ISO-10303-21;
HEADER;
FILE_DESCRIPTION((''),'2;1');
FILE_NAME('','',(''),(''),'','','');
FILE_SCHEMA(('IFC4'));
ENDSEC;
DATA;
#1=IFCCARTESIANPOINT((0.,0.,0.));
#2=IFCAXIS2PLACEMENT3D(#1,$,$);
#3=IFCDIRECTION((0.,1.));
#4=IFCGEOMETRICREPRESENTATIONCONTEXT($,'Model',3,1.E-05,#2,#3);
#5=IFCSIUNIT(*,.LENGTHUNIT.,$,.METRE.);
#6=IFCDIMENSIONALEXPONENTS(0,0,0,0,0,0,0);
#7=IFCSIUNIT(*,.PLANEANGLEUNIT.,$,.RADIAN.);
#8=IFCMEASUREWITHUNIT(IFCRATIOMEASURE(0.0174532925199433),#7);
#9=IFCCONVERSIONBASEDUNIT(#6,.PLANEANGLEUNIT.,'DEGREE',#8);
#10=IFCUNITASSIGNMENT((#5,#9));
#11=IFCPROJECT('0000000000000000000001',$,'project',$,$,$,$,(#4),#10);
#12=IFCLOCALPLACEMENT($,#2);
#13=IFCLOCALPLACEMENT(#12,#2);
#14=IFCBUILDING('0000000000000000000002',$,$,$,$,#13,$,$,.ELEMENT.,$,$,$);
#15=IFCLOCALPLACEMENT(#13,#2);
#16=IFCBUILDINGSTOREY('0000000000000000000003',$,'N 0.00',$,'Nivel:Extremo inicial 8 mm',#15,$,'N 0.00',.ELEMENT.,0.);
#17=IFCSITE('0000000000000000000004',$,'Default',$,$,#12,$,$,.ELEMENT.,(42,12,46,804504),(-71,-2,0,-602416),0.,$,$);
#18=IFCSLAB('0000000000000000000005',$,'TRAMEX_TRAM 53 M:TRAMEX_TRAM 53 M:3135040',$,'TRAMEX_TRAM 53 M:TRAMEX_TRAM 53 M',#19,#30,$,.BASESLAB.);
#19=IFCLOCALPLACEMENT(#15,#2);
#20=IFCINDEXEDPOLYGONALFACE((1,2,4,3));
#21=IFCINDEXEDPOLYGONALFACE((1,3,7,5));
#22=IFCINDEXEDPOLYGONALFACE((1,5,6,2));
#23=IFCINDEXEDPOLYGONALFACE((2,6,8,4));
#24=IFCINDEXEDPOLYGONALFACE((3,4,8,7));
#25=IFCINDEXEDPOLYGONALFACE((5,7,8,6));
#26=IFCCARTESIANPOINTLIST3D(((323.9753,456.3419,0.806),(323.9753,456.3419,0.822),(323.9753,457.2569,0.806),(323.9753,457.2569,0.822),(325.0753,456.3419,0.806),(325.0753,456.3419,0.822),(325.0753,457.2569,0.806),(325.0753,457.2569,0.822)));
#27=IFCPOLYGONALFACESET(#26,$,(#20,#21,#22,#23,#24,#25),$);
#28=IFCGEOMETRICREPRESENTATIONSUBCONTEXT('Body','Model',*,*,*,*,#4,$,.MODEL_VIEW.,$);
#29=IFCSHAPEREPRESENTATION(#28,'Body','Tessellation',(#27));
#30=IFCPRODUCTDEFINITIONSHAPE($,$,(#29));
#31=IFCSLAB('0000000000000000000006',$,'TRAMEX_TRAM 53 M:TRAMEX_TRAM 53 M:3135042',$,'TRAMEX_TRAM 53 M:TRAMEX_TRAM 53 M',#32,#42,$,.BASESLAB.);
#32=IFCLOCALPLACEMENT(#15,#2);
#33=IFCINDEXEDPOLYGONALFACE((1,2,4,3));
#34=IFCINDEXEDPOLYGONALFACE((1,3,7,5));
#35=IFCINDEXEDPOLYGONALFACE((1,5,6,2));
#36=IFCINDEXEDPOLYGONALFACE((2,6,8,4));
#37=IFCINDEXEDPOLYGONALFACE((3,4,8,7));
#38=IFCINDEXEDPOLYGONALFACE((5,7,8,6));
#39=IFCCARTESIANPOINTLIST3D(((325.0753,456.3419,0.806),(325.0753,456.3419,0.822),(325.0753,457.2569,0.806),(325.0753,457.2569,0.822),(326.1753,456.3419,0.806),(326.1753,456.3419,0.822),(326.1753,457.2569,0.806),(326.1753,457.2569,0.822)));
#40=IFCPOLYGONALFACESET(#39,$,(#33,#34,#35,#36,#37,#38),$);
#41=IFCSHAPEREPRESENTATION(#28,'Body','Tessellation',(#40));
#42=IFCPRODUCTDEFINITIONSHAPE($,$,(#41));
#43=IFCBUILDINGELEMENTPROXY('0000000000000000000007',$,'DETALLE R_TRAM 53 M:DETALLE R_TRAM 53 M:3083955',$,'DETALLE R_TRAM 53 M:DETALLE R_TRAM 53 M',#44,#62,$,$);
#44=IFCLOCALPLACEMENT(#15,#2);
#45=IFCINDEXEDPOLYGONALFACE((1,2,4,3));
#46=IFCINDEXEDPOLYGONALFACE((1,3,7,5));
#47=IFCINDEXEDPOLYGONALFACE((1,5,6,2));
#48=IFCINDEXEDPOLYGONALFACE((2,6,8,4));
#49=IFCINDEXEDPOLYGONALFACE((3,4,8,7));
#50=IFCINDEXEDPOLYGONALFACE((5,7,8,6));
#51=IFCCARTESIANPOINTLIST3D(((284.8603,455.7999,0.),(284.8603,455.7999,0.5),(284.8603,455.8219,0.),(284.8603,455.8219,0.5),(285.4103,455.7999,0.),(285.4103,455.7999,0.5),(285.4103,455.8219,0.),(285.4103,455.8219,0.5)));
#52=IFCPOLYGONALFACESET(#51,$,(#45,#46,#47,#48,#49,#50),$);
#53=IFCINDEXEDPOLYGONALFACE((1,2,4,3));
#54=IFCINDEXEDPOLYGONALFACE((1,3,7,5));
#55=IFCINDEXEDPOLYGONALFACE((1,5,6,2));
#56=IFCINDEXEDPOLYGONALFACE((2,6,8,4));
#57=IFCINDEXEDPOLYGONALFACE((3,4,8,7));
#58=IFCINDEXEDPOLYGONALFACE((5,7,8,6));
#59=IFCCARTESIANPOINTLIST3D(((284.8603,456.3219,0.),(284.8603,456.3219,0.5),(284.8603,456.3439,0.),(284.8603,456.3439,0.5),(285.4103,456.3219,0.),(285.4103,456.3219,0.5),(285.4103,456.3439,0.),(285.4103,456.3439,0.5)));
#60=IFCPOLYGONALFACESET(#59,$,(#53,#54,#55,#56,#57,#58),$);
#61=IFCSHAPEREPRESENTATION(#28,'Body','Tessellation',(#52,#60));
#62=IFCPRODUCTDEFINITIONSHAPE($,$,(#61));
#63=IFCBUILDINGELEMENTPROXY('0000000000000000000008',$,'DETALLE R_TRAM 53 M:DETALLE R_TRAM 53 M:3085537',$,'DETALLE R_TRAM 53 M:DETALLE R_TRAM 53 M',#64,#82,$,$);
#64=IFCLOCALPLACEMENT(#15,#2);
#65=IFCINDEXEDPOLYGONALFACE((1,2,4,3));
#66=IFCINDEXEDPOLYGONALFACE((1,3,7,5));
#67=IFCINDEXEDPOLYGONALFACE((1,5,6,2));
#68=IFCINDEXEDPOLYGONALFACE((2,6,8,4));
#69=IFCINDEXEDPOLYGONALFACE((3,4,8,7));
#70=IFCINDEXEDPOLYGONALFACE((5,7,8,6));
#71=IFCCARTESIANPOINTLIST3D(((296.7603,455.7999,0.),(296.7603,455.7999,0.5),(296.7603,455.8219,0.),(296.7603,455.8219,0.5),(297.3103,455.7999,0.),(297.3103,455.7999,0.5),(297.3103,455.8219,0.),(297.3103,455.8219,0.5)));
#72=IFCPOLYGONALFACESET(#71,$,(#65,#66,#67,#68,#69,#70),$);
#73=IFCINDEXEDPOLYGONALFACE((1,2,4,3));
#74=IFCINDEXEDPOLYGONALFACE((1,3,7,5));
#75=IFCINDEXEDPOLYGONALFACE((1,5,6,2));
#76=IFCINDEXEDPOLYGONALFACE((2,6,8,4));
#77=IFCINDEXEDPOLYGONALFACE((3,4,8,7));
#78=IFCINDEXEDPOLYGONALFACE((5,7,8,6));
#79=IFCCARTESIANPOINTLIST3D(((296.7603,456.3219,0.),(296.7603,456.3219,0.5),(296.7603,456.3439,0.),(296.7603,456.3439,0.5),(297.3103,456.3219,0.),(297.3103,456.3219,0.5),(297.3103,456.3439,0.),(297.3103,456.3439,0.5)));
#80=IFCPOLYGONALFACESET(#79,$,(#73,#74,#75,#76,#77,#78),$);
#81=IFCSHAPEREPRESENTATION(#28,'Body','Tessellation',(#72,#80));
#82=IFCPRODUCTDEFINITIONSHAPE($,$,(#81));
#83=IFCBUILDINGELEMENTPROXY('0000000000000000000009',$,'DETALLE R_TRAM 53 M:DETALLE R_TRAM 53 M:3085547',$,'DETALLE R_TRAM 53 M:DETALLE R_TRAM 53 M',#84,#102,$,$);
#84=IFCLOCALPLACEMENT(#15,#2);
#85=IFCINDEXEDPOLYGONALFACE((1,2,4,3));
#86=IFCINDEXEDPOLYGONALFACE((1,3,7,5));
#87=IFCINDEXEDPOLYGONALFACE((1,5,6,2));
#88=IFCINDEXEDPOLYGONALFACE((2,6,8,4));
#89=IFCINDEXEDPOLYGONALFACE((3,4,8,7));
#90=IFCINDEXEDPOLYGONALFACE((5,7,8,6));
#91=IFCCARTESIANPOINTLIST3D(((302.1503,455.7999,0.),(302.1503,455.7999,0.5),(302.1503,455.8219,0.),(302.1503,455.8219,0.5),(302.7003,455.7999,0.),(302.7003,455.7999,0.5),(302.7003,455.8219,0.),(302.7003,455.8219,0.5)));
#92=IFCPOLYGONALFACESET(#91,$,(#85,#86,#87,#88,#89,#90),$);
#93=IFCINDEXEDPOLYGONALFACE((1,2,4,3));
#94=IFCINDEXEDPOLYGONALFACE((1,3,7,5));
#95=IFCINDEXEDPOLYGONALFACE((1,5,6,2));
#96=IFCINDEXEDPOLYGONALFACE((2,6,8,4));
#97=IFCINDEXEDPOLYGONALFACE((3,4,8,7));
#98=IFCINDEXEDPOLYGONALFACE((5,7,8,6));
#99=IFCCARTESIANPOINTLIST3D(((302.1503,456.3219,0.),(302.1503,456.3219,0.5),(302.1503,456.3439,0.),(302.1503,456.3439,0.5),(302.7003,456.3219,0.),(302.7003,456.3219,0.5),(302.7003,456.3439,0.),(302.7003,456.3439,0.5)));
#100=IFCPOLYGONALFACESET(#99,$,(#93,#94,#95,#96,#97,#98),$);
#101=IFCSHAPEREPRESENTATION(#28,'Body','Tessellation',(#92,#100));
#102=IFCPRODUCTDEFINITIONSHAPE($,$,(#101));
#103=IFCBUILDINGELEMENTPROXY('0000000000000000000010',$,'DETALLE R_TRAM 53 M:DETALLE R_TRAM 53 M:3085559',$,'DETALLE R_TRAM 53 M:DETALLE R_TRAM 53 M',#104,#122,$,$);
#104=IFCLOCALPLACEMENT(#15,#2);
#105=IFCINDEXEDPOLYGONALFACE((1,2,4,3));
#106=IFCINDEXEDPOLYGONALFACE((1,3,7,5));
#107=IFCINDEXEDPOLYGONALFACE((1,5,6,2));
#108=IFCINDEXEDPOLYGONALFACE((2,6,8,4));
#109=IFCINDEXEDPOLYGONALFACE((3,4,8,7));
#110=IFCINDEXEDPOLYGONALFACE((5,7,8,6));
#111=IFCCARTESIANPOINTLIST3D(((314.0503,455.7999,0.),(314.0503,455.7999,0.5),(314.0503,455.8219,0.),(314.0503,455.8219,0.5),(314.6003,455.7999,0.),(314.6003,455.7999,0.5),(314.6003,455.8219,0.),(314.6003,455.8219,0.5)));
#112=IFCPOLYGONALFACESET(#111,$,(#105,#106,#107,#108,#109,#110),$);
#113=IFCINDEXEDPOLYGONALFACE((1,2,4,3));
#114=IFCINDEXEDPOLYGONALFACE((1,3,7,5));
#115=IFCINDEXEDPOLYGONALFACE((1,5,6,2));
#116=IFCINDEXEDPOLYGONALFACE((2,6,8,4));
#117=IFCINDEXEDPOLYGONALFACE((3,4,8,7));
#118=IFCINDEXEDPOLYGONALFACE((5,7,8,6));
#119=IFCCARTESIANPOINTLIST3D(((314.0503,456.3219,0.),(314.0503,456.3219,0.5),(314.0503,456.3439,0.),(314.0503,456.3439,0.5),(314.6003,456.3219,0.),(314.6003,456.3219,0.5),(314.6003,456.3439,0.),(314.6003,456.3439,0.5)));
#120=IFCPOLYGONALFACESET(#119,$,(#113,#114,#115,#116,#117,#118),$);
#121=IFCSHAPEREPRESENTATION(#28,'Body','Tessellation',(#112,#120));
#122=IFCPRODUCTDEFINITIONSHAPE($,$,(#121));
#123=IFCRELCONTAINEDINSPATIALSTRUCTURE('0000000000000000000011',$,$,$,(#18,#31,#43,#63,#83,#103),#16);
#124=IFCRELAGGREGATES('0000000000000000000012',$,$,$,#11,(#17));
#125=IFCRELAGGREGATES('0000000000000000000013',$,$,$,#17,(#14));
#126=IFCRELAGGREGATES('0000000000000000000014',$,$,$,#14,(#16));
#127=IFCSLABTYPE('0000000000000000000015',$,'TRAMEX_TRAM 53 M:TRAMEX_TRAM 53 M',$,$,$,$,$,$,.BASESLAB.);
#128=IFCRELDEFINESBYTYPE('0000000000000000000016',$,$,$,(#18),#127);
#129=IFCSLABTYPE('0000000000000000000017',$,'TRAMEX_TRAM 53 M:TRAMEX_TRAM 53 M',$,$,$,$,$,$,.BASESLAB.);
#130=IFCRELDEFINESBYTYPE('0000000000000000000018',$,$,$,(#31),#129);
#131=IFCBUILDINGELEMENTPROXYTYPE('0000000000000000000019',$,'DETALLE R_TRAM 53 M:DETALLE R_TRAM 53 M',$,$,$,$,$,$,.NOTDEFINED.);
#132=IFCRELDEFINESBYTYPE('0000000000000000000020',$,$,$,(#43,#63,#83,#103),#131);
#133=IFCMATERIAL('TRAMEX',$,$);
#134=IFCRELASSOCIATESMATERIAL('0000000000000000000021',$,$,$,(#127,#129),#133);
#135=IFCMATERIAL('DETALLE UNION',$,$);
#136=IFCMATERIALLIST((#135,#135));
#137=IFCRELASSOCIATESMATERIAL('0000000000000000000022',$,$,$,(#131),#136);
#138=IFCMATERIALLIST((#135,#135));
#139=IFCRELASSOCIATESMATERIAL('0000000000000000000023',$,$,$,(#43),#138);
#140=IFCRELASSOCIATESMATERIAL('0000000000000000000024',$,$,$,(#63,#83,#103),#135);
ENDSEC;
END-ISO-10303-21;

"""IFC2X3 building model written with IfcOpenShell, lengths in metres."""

from ifc_helpers import new_model, entity, si_unit, converted_unit, direction, frame, frame_2d, origin, place, context, subcontext, project, spatial, rectangle, extrude, source, transform, mapped, material, material_list, type_object, type_shapes, element, save


model = new_model("IFC2X3")

# Units and contexts
model_context = context("Model", 3, precision=1e-05, world=origin(), true_north=direction((0.0, 1.0)))
body_context = subcontext(model_context, "Body", "Model", "MODEL_VIEW")
ifc_project = project(units=[si_unit("LENGTHUNIT", "METRE"), converted_unit("PLANEANGLEUNIT", "DEGREE", entity("IfcRatioMeasure", 0.0174532925199433), si_unit("PLANEANGLEUNIT", "RADIAN"), dimensions=[0, 0, 0, 0, 0, 0, 0])], contexts=[model_context])

# Site, building, storey
site_placement = place(None, origin())
site = spatial("IfcSite", under=ifc_project, at=site_placement, Name="Default", CompositionType="ELEMENT", RefLatitude=(42, 12, 46, 804504), RefLongitude=(-71, -2, 0, -602416), RefElevation=0.0)
building_placement = place(site_placement, origin())
building = spatial("IfcBuilding", under=site, at=building_placement, CompositionType="ELEMENT")
storey_placement = place(building_placement, origin())
storey = spatial("IfcBuildingStorey", under=building, at=storey_placement, Name="N 0.00", ObjectType="Nivel:Extremo inicial 8 mm", LongName="N 0.00", CompositionType="ELEMENT", Elevation=0.0)

# Slabs
ifc_material_1 = material(Name="TRAMEX")
slab_type_1 = type_object("IfcSlabType", Name="TRAMEX_TRAM 53 M:TRAMEX_TRAM 53 M", PredefinedType="BASESLAB", material=ifc_material_1)
slab_1_placement = place(storey_placement, origin())
element("IfcSlab", 1, at=slab_1_placement, inside=storey, type_object=slab_type_1, Name="TRAMEX_TRAM 53 M:TRAMEX_TRAM 53 M:3135040", ObjectType="TRAMEX_TRAM 53 M:TRAMEX_TRAM 53 M", PredefinedType="BASESLAB", context=body_context, shape_type="SweptSolid", body=[
    extrude(rectangle(XDim=1.1, YDim=0.915, at=frame_2d((0.0, 0.0), x_axis=(1.0, 0.0))), frame((324.5253, 456.7994, 0.806), z_axis=(0.0, 0.0, 1.0), x_axis=(-1.0, 0.0, 0.0)), (0.0, 0.0, 1.0), 0.016),
])
slab_type_2 = type_object("IfcSlabType", Name="TRAMEX_TRAM 53 M:TRAMEX_TRAM 53 M", PredefinedType="BASESLAB", material=ifc_material_1)
slab_2_placement = place(storey_placement, origin())
element("IfcSlab", 2, at=slab_2_placement, inside=storey, type_object=slab_type_2, Name="TRAMEX_TRAM 53 M:TRAMEX_TRAM 53 M:3135042", ObjectType="TRAMEX_TRAM 53 M:TRAMEX_TRAM 53 M", PredefinedType="BASESLAB", context=body_context, shape_type="SweptSolid", body=[
    extrude(rectangle(XDim=1.1, YDim=0.915, at=frame_2d((0.0, 0.0), x_axis=(1.0, 0.0))), frame((325.6253, 456.7994, 0.806), z_axis=(0.0, 0.0, 1.0), x_axis=(-1.0, 0.0, 0.0)), (0.0, 0.0, 1.0), 0.016),
])

# Building element proxies
ifc_material_2 = material(Name="DETALLE UNION")
ifc_material_list_1 = material_list([ifc_material_2, ifc_material_2])
ifc_material_list_2 = material_list([ifc_material_2, ifc_material_2])
building_element_proxy_type_1 = type_object("IfcBuildingElementProxyType", Name="DETALLE R_TRAM 53 M:DETALLE R_TRAM 53 M", PredefinedType="NOTDEFINED", material=ifc_material_list_2)
shared_shape_1 = source(origin(), body_context, "Body", "SweptSolid", [
    extrude(rectangle(XDim=0.022, YDim=0.55, at=frame_2d((0.0, 0.0), x_axis=(1.0, 0.0))), frame((0.275, -0.011, 0.0), z_axis=(0.0, 0.0, 1.0), x_axis=(0.0, 1.0, 0.0)), (0.0, 0.0, 1.0), 0.5),
    extrude(rectangle(XDim=0.022, YDim=0.55, at=frame_2d((0.0, 0.0), x_axis=(1.0, 0.0))), frame((0.275, 0.511, 0.0), z_axis=(0.0, 0.0, 1.0), x_axis=(0.0, 1.0, 0.0)), (0.0, 0.0, 1.0), 0.5),
])
type_shapes(building_element_proxy_type_1, [shared_shape_1])
proxy_1_placement = place(storey_placement, frame((284.8603, 455.8219, 0.0)))
element("IfcBuildingElementProxy", 3, at=proxy_1_placement, inside=storey, type_object=building_element_proxy_type_1, material=ifc_material_list_1, Name="DETALLE R_TRAM 53 M:DETALLE R_TRAM 53 M:3083955", ObjectType="DETALLE R_TRAM 53 M:DETALLE R_TRAM 53 M", context=body_context, shape_type="MappedRepresentation", body=[
    mapped(shared_shape_1, transform((0.0, 0.0, 0.0), scale=1.0)),
])
for number, where, name in (
    (4, (296.7603, 455.8219, 0.0), "DETALLE R_TRAM 53 M:DETALLE R_TRAM 53 M:3085537"),
    (5, (302.1503, 455.8219, 0.0), "DETALLE R_TRAM 53 M:DETALLE R_TRAM 53 M:3085547"),
    (6, (314.0503, 455.8219, 0.0), "DETALLE R_TRAM 53 M:DETALLE R_TRAM 53 M:3085559"),
):
    element("IfcBuildingElementProxy", number, at=place(storey_placement, frame(where)), inside=storey, type_object=building_element_proxy_type_1, material=ifc_material_2, Name=name, ObjectType="DETALLE R_TRAM 53 M:DETALLE R_TRAM 53 M", context=body_context, shape_type="MappedRepresentation", body=[
        mapped(shared_shape_1, transform((0.0, 0.0, 0.0), scale=1.0)),
    ])

save(model, "model.ifc")
